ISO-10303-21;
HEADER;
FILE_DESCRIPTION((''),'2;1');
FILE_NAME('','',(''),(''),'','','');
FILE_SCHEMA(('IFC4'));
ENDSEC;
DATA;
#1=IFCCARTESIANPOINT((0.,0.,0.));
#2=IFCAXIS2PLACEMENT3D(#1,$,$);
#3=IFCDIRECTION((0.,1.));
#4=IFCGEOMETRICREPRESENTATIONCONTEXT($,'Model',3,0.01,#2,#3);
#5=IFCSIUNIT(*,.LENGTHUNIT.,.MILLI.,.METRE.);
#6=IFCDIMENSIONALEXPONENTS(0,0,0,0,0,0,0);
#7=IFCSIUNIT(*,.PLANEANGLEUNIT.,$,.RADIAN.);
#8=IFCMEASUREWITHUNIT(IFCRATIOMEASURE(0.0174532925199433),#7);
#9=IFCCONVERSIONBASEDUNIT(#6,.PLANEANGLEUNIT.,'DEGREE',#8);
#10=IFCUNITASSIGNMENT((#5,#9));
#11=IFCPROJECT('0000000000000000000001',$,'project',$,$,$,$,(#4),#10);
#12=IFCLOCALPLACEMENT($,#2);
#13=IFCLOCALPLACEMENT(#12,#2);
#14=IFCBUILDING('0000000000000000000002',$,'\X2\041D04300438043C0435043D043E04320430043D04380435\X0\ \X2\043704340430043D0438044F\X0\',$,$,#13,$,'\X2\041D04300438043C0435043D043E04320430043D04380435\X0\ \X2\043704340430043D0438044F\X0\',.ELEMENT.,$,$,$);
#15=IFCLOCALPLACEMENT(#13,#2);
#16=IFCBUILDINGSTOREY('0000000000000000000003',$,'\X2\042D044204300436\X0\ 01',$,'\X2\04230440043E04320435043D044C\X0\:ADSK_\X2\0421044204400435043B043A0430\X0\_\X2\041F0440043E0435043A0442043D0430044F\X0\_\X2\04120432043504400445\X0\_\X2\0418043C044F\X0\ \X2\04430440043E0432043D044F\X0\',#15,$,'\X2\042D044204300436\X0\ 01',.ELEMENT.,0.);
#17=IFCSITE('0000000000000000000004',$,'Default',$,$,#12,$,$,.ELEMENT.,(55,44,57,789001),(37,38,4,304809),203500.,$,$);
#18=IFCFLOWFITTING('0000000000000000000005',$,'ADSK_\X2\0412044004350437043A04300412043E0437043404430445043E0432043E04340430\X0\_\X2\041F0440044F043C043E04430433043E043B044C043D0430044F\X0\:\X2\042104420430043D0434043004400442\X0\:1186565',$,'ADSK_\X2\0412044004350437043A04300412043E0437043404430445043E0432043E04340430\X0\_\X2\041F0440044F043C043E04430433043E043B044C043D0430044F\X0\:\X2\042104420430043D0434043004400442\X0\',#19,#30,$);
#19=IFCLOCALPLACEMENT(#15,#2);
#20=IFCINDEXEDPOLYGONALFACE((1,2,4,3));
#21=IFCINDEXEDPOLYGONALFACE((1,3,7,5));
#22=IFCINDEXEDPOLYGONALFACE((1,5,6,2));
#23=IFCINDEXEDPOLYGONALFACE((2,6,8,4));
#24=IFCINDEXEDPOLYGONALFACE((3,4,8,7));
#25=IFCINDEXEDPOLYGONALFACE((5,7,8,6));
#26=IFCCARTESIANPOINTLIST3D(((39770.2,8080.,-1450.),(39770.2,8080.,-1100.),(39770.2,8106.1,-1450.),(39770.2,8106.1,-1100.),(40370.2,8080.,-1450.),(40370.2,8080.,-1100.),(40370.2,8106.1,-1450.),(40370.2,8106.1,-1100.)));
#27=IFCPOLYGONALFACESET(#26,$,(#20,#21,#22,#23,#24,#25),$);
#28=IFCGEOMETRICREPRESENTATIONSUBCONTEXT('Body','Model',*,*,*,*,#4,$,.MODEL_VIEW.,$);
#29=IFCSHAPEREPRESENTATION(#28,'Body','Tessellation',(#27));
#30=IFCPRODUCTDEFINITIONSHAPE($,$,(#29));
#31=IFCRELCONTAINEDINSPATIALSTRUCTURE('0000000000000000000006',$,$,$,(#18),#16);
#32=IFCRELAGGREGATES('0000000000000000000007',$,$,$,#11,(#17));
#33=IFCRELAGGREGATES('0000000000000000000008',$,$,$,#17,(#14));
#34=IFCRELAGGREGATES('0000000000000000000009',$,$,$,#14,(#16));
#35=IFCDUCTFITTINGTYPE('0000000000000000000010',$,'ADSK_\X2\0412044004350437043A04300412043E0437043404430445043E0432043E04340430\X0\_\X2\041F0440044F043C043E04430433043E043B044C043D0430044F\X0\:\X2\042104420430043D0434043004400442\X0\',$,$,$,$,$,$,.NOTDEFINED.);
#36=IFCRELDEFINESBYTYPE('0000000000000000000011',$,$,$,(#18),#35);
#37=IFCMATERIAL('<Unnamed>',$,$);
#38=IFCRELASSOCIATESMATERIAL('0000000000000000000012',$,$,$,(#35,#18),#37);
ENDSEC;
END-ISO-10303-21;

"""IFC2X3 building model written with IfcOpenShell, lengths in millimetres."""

from ifc_helpers import new_model, entity, si_unit, converted_unit, direction, frame, frame_2d, origin, place, context, subcontext, project, spatial, rectangle, extrude, source, transform, mapped, material, type_object, type_shapes, element, save


model = new_model("IFC2X3")

# Units and contexts
model_context = context("Model", 3, precision=0.01, world=origin(), true_north=direction((0.0, 1.0)))
body_context = subcontext(model_context, "Body", "Model", "MODEL_VIEW")
ifc_project = project(units=[si_unit("LENGTHUNIT", "METRE", prefix="MILLI"), converted_unit("PLANEANGLEUNIT", "DEGREE", entity("IfcRatioMeasure", 0.0174532925199433), si_unit("PLANEANGLEUNIT", "RADIAN"), dimensions=[0, 0, 0, 0, 0, 0, 0])], contexts=[model_context])

# Site, building, storey
site_placement = place(None, frame((0.0, 0.0, 0.0)))
site = spatial("IfcSite", under=ifc_project, at=site_placement, Name="Default", CompositionType="ELEMENT", RefLatitude=(55, 44, 57, 789001), RefLongitude=(37, 38, 4, 304809), RefElevation=203500.0)
building_placement = place(site_placement, origin())
building = spatial("IfcBuilding", under=site, at=building_placement, Name="Наименование здания", LongName="Наименование здания", CompositionType="ELEMENT")
storey_placement = place(building_placement, origin())
storey = spatial("IfcBuildingStorey", under=building, at=storey_placement, Name="Этаж 01", ObjectType="Уровень:ADSK_Стрелка_Проектная_Вверх_Имя уровня", LongName="Этаж 01", CompositionType="ELEMENT", Elevation=0.0)

# Shared definitions
ifc_material_1 = material(Name="<Unnamed>")

# Flow fitting
duct_fitting_type_1 = type_object("IfcDuctFittingType", Name="ADSK_ВрезкаВоздуховода_Прямоугольная:Стандарт", PredefinedType="NOTDEFINED", material=ifc_material_1)
shared_shape_1 = source(origin(), body_context, "Body", "SweptSolid", [
    extrude(rectangle(XDim=26.1, YDim=600.0, at=frame_2d((0.0, 0.0), x_axis=(1.0, 0.0))), frame((7.0, 0.0, -175.0)), (0.0, 0.0, 1.0), 350.0),
])
type_shapes(duct_fitting_type_1, [shared_shape_1])
flow_fitting_1_placement = place(storey_placement, frame((40070.2, 8100.0, -1275.0), z_axis=(0.0, 0.0, -1.0), x_axis=(0.0, -1.0, 0.0)))
element("IfcFlowFitting", 1, at=flow_fitting_1_placement, inside=storey, type_object=duct_fitting_type_1, material=ifc_material_1, Name="ADSK_ВрезкаВоздуховода_Прямоугольная:Стандарт:1186565", ObjectType="ADSK_ВрезкаВоздуховода_Прямоугольная:Стандарт", context=body_context, shape_type="MappedRepresentation", body=[
    mapped(shared_shape_1, transform((0.0, 0.0, 0.0), scale=1.0)),
])

save(model, "model.ifc")
